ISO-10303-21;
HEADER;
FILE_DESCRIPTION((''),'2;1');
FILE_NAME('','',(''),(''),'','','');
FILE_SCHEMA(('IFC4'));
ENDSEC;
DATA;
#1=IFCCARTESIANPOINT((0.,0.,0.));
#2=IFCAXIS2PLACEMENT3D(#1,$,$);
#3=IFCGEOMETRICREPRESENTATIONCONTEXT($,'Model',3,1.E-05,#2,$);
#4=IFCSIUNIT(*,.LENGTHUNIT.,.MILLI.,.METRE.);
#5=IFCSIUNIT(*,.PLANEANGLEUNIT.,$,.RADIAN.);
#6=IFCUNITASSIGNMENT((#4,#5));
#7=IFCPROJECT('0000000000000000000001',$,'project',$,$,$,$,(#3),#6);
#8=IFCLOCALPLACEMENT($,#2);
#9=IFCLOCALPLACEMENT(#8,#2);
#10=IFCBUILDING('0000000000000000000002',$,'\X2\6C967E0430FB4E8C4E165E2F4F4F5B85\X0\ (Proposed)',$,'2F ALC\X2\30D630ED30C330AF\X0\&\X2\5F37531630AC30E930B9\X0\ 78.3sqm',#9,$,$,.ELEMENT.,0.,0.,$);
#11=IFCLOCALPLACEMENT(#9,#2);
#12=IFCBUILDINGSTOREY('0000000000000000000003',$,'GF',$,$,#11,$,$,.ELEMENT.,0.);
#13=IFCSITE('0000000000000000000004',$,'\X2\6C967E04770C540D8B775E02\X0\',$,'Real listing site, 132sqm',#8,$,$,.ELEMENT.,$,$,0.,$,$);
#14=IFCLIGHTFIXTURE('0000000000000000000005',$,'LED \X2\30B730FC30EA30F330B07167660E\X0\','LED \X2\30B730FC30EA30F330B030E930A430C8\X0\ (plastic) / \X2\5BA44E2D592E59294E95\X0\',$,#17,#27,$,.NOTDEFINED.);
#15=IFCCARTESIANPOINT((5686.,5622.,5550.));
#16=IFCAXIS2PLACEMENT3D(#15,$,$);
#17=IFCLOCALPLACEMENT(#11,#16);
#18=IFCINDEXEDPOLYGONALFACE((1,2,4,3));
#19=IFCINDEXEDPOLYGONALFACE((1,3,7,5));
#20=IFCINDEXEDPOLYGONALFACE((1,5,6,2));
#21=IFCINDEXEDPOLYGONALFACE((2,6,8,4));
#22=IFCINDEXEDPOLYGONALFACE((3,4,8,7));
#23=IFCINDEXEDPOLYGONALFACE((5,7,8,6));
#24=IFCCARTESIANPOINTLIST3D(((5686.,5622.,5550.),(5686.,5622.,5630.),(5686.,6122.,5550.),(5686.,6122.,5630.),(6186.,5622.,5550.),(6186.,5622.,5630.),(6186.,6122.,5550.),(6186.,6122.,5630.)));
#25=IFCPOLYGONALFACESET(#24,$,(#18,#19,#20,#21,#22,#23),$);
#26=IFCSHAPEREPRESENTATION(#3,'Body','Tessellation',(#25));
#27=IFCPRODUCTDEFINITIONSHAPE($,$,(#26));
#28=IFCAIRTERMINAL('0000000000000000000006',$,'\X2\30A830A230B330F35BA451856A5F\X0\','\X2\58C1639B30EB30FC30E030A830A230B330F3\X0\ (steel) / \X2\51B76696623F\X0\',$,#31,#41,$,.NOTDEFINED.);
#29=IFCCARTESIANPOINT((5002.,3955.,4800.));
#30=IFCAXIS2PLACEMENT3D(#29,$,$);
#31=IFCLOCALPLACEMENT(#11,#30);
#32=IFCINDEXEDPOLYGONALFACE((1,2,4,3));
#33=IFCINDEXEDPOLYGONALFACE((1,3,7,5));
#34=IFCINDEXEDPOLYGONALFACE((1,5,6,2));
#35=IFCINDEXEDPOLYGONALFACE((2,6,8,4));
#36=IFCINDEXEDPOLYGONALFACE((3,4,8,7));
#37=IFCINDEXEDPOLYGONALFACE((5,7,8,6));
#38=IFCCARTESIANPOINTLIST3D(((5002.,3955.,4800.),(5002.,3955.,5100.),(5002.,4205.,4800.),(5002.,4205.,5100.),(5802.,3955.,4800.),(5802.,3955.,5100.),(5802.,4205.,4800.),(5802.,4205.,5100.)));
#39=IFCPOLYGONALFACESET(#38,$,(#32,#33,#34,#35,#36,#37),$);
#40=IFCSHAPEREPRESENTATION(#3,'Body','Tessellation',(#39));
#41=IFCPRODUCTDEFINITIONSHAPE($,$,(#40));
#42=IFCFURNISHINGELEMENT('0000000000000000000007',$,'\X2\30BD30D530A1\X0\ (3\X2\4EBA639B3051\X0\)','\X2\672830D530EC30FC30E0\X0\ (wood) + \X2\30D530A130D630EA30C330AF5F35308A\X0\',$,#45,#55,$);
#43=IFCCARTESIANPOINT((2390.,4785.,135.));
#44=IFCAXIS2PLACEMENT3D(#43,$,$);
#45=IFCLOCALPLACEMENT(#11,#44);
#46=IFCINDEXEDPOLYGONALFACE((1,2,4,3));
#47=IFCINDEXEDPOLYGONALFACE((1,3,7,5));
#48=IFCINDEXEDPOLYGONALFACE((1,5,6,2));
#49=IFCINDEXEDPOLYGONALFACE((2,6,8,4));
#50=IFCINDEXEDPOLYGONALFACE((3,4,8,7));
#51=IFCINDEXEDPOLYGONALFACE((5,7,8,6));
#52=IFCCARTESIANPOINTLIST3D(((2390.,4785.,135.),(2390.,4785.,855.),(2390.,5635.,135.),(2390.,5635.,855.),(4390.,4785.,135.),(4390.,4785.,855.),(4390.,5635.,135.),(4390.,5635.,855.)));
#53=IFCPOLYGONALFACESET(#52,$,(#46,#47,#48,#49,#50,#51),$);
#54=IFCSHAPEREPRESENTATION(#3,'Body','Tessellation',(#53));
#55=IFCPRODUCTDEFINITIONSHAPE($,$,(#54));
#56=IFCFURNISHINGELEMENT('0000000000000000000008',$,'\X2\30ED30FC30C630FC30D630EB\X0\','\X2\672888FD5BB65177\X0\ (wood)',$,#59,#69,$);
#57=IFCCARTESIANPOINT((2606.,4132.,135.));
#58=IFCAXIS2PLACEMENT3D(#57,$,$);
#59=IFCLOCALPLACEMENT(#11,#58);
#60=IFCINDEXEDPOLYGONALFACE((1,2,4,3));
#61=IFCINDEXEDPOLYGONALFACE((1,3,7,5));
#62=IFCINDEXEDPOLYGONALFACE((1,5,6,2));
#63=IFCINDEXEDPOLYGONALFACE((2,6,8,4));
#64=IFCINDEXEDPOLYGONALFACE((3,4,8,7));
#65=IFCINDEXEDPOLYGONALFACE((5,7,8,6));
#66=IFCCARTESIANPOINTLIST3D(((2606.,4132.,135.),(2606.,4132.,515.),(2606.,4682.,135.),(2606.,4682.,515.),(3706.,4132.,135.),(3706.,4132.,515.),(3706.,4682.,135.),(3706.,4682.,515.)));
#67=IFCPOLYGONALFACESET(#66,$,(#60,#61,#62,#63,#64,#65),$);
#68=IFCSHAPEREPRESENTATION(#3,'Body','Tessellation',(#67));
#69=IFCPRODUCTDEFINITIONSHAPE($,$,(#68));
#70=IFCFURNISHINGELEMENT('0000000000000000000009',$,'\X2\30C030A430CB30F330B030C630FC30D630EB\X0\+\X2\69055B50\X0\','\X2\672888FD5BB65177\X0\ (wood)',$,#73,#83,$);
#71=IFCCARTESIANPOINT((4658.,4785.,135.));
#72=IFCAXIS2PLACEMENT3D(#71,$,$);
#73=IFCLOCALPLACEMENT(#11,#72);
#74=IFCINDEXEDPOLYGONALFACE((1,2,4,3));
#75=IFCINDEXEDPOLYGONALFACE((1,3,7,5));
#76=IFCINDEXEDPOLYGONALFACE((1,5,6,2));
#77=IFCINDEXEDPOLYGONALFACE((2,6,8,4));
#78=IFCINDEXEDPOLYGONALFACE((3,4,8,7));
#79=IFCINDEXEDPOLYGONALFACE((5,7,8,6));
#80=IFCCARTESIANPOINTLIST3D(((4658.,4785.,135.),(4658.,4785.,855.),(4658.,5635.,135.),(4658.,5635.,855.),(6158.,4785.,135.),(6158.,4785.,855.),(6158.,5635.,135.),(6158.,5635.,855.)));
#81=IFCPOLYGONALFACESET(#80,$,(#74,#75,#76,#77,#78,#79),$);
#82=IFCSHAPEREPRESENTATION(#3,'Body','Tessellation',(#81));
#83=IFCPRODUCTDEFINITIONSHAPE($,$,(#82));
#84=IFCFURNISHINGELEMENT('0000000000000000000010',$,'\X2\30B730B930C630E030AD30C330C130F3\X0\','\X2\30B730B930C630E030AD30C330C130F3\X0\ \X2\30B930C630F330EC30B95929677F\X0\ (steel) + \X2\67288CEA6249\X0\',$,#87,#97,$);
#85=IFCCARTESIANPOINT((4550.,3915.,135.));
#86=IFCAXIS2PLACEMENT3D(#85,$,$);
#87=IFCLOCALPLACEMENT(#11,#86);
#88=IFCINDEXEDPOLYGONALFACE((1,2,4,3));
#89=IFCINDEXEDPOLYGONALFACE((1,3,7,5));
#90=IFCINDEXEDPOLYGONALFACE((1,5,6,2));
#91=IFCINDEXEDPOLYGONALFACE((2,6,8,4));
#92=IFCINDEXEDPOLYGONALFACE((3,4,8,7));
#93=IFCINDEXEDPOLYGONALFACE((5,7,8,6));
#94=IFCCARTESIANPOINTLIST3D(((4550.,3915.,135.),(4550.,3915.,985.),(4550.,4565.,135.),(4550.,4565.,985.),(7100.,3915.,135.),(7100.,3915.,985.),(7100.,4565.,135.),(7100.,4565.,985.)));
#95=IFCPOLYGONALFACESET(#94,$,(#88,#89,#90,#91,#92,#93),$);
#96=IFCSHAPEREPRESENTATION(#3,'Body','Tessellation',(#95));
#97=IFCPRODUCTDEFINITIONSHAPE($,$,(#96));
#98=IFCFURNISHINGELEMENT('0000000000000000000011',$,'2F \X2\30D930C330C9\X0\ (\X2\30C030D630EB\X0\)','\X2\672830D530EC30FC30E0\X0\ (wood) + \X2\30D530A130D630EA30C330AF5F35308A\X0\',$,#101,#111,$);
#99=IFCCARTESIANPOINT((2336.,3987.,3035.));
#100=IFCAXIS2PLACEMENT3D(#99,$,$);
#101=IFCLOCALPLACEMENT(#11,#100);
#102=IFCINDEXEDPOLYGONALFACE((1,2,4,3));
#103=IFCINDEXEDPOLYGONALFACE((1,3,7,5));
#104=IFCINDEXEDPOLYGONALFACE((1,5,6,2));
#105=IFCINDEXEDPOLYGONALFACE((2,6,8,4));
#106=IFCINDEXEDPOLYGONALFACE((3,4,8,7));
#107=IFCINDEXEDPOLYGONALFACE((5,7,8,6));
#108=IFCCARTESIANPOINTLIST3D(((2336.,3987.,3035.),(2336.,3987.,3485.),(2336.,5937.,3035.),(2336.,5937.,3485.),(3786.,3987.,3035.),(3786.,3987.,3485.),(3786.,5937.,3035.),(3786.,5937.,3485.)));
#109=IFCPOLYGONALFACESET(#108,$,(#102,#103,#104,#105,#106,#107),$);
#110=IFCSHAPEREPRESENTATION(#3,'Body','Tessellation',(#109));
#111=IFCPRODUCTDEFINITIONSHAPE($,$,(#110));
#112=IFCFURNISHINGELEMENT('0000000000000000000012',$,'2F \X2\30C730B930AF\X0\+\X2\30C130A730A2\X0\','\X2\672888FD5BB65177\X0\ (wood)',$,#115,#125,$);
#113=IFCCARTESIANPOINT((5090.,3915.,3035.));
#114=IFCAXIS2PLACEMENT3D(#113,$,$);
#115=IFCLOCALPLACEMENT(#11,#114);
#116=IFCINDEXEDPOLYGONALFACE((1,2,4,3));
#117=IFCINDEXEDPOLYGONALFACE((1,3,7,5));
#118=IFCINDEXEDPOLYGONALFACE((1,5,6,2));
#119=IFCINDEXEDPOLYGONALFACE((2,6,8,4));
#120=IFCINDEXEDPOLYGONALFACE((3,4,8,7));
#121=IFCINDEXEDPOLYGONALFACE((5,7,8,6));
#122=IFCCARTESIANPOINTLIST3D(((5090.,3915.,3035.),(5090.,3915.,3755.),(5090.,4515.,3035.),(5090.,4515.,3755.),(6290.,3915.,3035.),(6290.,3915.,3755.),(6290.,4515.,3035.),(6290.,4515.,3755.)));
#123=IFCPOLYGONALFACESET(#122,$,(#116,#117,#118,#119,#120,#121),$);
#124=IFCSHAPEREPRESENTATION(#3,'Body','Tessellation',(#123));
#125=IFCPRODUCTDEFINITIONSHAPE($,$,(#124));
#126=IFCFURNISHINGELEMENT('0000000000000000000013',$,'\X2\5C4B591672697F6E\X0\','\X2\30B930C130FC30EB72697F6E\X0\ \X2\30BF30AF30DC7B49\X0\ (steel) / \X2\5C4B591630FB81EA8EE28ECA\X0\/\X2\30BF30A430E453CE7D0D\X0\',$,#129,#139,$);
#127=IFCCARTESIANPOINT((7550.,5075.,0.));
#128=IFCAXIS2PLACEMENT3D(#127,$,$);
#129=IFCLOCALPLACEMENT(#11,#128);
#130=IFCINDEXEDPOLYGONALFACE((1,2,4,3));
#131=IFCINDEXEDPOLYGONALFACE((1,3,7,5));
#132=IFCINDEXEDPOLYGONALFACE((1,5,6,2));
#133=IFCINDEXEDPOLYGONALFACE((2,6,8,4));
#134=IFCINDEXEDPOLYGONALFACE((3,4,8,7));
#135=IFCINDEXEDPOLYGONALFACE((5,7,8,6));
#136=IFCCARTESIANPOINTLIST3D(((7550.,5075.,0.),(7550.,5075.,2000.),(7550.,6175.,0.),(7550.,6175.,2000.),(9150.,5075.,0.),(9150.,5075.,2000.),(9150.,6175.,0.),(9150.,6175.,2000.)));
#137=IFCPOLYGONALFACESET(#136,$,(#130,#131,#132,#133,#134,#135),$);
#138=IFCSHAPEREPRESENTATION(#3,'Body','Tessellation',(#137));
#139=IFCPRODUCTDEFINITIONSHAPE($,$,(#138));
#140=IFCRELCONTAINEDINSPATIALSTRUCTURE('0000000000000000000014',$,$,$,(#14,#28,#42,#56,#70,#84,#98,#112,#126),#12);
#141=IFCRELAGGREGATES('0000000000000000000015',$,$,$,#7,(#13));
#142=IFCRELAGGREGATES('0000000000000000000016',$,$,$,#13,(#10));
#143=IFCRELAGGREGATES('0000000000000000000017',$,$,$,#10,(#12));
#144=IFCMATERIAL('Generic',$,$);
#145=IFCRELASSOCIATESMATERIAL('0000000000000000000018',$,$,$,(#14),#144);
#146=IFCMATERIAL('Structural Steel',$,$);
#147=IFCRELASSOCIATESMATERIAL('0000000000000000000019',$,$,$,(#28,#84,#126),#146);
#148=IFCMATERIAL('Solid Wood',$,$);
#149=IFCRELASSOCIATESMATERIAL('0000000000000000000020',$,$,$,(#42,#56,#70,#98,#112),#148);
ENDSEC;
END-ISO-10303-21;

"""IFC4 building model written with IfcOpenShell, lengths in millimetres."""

from ifc_helpers import new_model, si_unit, frame, frame_2d, origin, place, context, project, spatial, rectangle, extrude, material, element, save


model = new_model("IFC4")

# Units and contexts
model_context = context("Model", 3, precision=1e-05, world=origin())
ifc_project = project(units=[si_unit("LENGTHUNIT", "METRE", prefix="MILLI"), si_unit("PLANEANGLEUNIT", "RADIAN")], contexts=[model_context])

# Site, building, storey
site_placement = place(None, origin())
site = spatial("IfcSite", under=ifc_project, at=site_placement, Name="沖縄県名護市", ObjectType="Real listing site, 132sqm", CompositionType="ELEMENT", RefElevation=0.0)
building_placement = place(site_placement, origin())
building = spatial("IfcBuilding", under=site, at=building_placement, Name="沖縄・二世帯住宅 (Proposed)", ObjectType="2F ALCブロック&強化ガラス 78.3sqm", CompositionType="ELEMENT", ElevationOfRefHeight=0.0, ElevationOfTerrain=0.0)
storey_placement = place(building_placement, origin())
storey = spatial("IfcBuildingStorey", under=building, at=storey_placement, Name="GF", CompositionType="ELEMENT", Elevation=0.0)

# Shared definitions
ifc_material_1 = material(Name="Solid Wood")

# Shared definitions
ifc_material_2 = material(Name="Generic")

# Shared definitions
ifc_material_3 = material(Name="Structural Steel")

# Light fixture
light_fixture_placement = place(storey_placement, frame((5686.0, 5622.0, 5550.0)))
element("IfcLightFixture", 1, at=light_fixture_placement, inside=storey, material=ifc_material_2, Name="LED シーリング照明", Description="LED シーリングライト (plastic) / 室中央天井", PredefinedType="NOTDEFINED", context=model_context, shape_type="SweptSolid", body=[
    extrude(rectangle(XDim=500.0, YDim=500.0, at=frame_2d((250.0, 250.0))), frame((5686.0, 5622.0, 5550.0)), (0.0, 0.0, 1.0), 80.0),
])

# Air terminal
air_terminal_1_placement = place(storey_placement, frame((5002.0, 3955.0, 4800.0)))
element("IfcAirTerminal", 2, at=air_terminal_1_placement, inside=storey, material=ifc_material_3, Name="エアコン室内機", Description="壁掛ルームエアコン (steel) / 冷暖房", PredefinedType="NOTDEFINED", context=model_context, shape_type="SweptSolid", body=[
    extrude(rectangle(XDim=800.0, YDim=250.0, at=frame_2d((400.0, 125.0))), frame((5002.0, 3955.0, 4800.0)), (0.0, 0.0, 1.0), 300.0),
])

# Furnishing elements
furnishing_1_placement = place(storey_placement, frame((2390.0, 4785.0, 135.0)))
element("IfcFurnishingElement", 3, at=furnishing_1_placement, inside=storey, material=ifc_material_1, Name="ソファ (3人掛け)", Description="木フレーム (wood) + ファブリック張り", context=model_context, shape_type="SweptSolid", body=[
    extrude(rectangle(XDim=2000.0, YDim=850.0, at=frame_2d((1000.0, 425.0))), frame((2390.0, 4785.0, 135.0)), (0.0, 0.0, 1.0), 720.0),
])
furnishing_2_placement = place(storey_placement, frame((2606.0, 4132.0, 135.0)))
element("IfcFurnishingElement", 4, at=furnishing_2_placement, inside=storey, material=ifc_material_1, Name="ローテーブル", Description="木製家具 (wood)", context=model_context, shape_type="SweptSolid", body=[
    extrude(rectangle(XDim=1100.0, YDim=550.0, at=frame_2d((550.0, 275.0))), frame((2606.0, 4132.0, 135.0)), (0.0, 0.0, 1.0), 380.0),
])
furnishing_3_placement = place(storey_placement, frame((4658.0, 4785.0, 135.0)))
element("IfcFurnishingElement", 5, at=furnishing_3_placement, inside=storey, material=ifc_material_1, Name="ダイニングテーブル+椅子", Description="木製家具 (wood)", context=model_context, shape_type="SweptSolid", body=[
    extrude(rectangle(XDim=1500.0, YDim=850.0, at=frame_2d((750.0, 425.0))), frame((4658.0, 4785.0, 135.0)), (0.0, 0.0, 1.0), 720.0),
])
furnishing_4_placement = place(storey_placement, frame((4550.0, 3915.0, 135.0)))
element("IfcFurnishingElement", 6, at=furnishing_4_placement, inside=storey, material=ifc_material_3, Name="システムキッチン", Description="システムキッチン ステンレス天板 (steel) + 木質扉", context=model_context, shape_type="SweptSolid", body=[
    extrude(rectangle(XDim=2550.0, YDim=650.0, at=frame_2d((1275.0, 325.0))), frame((4550.0, 3915.0, 135.0)), (0.0, 0.0, 1.0), 850.0),
])
furnishing_5_placement = place(storey_placement, frame((2336.0, 3987.0, 3035.0)))
element("IfcFurnishingElement", 7, at=furnishing_5_placement, inside=storey, material=ifc_material_1, Name="2F ベッド (ダブル)", Description="木フレーム (wood) + ファブリック張り", context=model_context, shape_type="SweptSolid", body=[
    extrude(rectangle(XDim=1450.0, YDim=1950.0, at=frame_2d((725.0, 975.0))), frame((2336.0, 3987.0, 3035.0)), (0.0, 0.0, 1.0), 450.0),
])
furnishing_6_placement = place(storey_placement, frame((5090.0, 3915.0, 3035.0)))
element("IfcFurnishingElement", 8, at=furnishing_6_placement, inside=storey, material=ifc_material_1, Name="2F デスク+チェア", Description="木製家具 (wood)", context=model_context, shape_type="SweptSolid", body=[
    extrude(rectangle(XDim=1200.0, YDim=600.0, at=frame_2d((600.0, 300.0))), frame((5090.0, 3915.0, 3035.0)), (0.0, 0.0, 1.0), 720.0),
])
furnishing_7_placement = place(storey_placement, frame((7550.0, 5075.0, 0.0)))
element("IfcFurnishingElement", 9, at=furnishing_7_placement, inside=storey, material=ifc_material_3, Name="屋外物置", Description="スチール物置 タクボ等 (steel) / 屋外・自転車/タイヤ収納", context=model_context, shape_type="SweptSolid", body=[
    extrude(rectangle(XDim=1600.0, YDim=1100.0, at=frame_2d((800.0, 550.0))), frame((7550.0, 5075.0, 0.0)), (0.0, 0.0, 1.0), 2000.0),
])

save(model, "model.ifc")
